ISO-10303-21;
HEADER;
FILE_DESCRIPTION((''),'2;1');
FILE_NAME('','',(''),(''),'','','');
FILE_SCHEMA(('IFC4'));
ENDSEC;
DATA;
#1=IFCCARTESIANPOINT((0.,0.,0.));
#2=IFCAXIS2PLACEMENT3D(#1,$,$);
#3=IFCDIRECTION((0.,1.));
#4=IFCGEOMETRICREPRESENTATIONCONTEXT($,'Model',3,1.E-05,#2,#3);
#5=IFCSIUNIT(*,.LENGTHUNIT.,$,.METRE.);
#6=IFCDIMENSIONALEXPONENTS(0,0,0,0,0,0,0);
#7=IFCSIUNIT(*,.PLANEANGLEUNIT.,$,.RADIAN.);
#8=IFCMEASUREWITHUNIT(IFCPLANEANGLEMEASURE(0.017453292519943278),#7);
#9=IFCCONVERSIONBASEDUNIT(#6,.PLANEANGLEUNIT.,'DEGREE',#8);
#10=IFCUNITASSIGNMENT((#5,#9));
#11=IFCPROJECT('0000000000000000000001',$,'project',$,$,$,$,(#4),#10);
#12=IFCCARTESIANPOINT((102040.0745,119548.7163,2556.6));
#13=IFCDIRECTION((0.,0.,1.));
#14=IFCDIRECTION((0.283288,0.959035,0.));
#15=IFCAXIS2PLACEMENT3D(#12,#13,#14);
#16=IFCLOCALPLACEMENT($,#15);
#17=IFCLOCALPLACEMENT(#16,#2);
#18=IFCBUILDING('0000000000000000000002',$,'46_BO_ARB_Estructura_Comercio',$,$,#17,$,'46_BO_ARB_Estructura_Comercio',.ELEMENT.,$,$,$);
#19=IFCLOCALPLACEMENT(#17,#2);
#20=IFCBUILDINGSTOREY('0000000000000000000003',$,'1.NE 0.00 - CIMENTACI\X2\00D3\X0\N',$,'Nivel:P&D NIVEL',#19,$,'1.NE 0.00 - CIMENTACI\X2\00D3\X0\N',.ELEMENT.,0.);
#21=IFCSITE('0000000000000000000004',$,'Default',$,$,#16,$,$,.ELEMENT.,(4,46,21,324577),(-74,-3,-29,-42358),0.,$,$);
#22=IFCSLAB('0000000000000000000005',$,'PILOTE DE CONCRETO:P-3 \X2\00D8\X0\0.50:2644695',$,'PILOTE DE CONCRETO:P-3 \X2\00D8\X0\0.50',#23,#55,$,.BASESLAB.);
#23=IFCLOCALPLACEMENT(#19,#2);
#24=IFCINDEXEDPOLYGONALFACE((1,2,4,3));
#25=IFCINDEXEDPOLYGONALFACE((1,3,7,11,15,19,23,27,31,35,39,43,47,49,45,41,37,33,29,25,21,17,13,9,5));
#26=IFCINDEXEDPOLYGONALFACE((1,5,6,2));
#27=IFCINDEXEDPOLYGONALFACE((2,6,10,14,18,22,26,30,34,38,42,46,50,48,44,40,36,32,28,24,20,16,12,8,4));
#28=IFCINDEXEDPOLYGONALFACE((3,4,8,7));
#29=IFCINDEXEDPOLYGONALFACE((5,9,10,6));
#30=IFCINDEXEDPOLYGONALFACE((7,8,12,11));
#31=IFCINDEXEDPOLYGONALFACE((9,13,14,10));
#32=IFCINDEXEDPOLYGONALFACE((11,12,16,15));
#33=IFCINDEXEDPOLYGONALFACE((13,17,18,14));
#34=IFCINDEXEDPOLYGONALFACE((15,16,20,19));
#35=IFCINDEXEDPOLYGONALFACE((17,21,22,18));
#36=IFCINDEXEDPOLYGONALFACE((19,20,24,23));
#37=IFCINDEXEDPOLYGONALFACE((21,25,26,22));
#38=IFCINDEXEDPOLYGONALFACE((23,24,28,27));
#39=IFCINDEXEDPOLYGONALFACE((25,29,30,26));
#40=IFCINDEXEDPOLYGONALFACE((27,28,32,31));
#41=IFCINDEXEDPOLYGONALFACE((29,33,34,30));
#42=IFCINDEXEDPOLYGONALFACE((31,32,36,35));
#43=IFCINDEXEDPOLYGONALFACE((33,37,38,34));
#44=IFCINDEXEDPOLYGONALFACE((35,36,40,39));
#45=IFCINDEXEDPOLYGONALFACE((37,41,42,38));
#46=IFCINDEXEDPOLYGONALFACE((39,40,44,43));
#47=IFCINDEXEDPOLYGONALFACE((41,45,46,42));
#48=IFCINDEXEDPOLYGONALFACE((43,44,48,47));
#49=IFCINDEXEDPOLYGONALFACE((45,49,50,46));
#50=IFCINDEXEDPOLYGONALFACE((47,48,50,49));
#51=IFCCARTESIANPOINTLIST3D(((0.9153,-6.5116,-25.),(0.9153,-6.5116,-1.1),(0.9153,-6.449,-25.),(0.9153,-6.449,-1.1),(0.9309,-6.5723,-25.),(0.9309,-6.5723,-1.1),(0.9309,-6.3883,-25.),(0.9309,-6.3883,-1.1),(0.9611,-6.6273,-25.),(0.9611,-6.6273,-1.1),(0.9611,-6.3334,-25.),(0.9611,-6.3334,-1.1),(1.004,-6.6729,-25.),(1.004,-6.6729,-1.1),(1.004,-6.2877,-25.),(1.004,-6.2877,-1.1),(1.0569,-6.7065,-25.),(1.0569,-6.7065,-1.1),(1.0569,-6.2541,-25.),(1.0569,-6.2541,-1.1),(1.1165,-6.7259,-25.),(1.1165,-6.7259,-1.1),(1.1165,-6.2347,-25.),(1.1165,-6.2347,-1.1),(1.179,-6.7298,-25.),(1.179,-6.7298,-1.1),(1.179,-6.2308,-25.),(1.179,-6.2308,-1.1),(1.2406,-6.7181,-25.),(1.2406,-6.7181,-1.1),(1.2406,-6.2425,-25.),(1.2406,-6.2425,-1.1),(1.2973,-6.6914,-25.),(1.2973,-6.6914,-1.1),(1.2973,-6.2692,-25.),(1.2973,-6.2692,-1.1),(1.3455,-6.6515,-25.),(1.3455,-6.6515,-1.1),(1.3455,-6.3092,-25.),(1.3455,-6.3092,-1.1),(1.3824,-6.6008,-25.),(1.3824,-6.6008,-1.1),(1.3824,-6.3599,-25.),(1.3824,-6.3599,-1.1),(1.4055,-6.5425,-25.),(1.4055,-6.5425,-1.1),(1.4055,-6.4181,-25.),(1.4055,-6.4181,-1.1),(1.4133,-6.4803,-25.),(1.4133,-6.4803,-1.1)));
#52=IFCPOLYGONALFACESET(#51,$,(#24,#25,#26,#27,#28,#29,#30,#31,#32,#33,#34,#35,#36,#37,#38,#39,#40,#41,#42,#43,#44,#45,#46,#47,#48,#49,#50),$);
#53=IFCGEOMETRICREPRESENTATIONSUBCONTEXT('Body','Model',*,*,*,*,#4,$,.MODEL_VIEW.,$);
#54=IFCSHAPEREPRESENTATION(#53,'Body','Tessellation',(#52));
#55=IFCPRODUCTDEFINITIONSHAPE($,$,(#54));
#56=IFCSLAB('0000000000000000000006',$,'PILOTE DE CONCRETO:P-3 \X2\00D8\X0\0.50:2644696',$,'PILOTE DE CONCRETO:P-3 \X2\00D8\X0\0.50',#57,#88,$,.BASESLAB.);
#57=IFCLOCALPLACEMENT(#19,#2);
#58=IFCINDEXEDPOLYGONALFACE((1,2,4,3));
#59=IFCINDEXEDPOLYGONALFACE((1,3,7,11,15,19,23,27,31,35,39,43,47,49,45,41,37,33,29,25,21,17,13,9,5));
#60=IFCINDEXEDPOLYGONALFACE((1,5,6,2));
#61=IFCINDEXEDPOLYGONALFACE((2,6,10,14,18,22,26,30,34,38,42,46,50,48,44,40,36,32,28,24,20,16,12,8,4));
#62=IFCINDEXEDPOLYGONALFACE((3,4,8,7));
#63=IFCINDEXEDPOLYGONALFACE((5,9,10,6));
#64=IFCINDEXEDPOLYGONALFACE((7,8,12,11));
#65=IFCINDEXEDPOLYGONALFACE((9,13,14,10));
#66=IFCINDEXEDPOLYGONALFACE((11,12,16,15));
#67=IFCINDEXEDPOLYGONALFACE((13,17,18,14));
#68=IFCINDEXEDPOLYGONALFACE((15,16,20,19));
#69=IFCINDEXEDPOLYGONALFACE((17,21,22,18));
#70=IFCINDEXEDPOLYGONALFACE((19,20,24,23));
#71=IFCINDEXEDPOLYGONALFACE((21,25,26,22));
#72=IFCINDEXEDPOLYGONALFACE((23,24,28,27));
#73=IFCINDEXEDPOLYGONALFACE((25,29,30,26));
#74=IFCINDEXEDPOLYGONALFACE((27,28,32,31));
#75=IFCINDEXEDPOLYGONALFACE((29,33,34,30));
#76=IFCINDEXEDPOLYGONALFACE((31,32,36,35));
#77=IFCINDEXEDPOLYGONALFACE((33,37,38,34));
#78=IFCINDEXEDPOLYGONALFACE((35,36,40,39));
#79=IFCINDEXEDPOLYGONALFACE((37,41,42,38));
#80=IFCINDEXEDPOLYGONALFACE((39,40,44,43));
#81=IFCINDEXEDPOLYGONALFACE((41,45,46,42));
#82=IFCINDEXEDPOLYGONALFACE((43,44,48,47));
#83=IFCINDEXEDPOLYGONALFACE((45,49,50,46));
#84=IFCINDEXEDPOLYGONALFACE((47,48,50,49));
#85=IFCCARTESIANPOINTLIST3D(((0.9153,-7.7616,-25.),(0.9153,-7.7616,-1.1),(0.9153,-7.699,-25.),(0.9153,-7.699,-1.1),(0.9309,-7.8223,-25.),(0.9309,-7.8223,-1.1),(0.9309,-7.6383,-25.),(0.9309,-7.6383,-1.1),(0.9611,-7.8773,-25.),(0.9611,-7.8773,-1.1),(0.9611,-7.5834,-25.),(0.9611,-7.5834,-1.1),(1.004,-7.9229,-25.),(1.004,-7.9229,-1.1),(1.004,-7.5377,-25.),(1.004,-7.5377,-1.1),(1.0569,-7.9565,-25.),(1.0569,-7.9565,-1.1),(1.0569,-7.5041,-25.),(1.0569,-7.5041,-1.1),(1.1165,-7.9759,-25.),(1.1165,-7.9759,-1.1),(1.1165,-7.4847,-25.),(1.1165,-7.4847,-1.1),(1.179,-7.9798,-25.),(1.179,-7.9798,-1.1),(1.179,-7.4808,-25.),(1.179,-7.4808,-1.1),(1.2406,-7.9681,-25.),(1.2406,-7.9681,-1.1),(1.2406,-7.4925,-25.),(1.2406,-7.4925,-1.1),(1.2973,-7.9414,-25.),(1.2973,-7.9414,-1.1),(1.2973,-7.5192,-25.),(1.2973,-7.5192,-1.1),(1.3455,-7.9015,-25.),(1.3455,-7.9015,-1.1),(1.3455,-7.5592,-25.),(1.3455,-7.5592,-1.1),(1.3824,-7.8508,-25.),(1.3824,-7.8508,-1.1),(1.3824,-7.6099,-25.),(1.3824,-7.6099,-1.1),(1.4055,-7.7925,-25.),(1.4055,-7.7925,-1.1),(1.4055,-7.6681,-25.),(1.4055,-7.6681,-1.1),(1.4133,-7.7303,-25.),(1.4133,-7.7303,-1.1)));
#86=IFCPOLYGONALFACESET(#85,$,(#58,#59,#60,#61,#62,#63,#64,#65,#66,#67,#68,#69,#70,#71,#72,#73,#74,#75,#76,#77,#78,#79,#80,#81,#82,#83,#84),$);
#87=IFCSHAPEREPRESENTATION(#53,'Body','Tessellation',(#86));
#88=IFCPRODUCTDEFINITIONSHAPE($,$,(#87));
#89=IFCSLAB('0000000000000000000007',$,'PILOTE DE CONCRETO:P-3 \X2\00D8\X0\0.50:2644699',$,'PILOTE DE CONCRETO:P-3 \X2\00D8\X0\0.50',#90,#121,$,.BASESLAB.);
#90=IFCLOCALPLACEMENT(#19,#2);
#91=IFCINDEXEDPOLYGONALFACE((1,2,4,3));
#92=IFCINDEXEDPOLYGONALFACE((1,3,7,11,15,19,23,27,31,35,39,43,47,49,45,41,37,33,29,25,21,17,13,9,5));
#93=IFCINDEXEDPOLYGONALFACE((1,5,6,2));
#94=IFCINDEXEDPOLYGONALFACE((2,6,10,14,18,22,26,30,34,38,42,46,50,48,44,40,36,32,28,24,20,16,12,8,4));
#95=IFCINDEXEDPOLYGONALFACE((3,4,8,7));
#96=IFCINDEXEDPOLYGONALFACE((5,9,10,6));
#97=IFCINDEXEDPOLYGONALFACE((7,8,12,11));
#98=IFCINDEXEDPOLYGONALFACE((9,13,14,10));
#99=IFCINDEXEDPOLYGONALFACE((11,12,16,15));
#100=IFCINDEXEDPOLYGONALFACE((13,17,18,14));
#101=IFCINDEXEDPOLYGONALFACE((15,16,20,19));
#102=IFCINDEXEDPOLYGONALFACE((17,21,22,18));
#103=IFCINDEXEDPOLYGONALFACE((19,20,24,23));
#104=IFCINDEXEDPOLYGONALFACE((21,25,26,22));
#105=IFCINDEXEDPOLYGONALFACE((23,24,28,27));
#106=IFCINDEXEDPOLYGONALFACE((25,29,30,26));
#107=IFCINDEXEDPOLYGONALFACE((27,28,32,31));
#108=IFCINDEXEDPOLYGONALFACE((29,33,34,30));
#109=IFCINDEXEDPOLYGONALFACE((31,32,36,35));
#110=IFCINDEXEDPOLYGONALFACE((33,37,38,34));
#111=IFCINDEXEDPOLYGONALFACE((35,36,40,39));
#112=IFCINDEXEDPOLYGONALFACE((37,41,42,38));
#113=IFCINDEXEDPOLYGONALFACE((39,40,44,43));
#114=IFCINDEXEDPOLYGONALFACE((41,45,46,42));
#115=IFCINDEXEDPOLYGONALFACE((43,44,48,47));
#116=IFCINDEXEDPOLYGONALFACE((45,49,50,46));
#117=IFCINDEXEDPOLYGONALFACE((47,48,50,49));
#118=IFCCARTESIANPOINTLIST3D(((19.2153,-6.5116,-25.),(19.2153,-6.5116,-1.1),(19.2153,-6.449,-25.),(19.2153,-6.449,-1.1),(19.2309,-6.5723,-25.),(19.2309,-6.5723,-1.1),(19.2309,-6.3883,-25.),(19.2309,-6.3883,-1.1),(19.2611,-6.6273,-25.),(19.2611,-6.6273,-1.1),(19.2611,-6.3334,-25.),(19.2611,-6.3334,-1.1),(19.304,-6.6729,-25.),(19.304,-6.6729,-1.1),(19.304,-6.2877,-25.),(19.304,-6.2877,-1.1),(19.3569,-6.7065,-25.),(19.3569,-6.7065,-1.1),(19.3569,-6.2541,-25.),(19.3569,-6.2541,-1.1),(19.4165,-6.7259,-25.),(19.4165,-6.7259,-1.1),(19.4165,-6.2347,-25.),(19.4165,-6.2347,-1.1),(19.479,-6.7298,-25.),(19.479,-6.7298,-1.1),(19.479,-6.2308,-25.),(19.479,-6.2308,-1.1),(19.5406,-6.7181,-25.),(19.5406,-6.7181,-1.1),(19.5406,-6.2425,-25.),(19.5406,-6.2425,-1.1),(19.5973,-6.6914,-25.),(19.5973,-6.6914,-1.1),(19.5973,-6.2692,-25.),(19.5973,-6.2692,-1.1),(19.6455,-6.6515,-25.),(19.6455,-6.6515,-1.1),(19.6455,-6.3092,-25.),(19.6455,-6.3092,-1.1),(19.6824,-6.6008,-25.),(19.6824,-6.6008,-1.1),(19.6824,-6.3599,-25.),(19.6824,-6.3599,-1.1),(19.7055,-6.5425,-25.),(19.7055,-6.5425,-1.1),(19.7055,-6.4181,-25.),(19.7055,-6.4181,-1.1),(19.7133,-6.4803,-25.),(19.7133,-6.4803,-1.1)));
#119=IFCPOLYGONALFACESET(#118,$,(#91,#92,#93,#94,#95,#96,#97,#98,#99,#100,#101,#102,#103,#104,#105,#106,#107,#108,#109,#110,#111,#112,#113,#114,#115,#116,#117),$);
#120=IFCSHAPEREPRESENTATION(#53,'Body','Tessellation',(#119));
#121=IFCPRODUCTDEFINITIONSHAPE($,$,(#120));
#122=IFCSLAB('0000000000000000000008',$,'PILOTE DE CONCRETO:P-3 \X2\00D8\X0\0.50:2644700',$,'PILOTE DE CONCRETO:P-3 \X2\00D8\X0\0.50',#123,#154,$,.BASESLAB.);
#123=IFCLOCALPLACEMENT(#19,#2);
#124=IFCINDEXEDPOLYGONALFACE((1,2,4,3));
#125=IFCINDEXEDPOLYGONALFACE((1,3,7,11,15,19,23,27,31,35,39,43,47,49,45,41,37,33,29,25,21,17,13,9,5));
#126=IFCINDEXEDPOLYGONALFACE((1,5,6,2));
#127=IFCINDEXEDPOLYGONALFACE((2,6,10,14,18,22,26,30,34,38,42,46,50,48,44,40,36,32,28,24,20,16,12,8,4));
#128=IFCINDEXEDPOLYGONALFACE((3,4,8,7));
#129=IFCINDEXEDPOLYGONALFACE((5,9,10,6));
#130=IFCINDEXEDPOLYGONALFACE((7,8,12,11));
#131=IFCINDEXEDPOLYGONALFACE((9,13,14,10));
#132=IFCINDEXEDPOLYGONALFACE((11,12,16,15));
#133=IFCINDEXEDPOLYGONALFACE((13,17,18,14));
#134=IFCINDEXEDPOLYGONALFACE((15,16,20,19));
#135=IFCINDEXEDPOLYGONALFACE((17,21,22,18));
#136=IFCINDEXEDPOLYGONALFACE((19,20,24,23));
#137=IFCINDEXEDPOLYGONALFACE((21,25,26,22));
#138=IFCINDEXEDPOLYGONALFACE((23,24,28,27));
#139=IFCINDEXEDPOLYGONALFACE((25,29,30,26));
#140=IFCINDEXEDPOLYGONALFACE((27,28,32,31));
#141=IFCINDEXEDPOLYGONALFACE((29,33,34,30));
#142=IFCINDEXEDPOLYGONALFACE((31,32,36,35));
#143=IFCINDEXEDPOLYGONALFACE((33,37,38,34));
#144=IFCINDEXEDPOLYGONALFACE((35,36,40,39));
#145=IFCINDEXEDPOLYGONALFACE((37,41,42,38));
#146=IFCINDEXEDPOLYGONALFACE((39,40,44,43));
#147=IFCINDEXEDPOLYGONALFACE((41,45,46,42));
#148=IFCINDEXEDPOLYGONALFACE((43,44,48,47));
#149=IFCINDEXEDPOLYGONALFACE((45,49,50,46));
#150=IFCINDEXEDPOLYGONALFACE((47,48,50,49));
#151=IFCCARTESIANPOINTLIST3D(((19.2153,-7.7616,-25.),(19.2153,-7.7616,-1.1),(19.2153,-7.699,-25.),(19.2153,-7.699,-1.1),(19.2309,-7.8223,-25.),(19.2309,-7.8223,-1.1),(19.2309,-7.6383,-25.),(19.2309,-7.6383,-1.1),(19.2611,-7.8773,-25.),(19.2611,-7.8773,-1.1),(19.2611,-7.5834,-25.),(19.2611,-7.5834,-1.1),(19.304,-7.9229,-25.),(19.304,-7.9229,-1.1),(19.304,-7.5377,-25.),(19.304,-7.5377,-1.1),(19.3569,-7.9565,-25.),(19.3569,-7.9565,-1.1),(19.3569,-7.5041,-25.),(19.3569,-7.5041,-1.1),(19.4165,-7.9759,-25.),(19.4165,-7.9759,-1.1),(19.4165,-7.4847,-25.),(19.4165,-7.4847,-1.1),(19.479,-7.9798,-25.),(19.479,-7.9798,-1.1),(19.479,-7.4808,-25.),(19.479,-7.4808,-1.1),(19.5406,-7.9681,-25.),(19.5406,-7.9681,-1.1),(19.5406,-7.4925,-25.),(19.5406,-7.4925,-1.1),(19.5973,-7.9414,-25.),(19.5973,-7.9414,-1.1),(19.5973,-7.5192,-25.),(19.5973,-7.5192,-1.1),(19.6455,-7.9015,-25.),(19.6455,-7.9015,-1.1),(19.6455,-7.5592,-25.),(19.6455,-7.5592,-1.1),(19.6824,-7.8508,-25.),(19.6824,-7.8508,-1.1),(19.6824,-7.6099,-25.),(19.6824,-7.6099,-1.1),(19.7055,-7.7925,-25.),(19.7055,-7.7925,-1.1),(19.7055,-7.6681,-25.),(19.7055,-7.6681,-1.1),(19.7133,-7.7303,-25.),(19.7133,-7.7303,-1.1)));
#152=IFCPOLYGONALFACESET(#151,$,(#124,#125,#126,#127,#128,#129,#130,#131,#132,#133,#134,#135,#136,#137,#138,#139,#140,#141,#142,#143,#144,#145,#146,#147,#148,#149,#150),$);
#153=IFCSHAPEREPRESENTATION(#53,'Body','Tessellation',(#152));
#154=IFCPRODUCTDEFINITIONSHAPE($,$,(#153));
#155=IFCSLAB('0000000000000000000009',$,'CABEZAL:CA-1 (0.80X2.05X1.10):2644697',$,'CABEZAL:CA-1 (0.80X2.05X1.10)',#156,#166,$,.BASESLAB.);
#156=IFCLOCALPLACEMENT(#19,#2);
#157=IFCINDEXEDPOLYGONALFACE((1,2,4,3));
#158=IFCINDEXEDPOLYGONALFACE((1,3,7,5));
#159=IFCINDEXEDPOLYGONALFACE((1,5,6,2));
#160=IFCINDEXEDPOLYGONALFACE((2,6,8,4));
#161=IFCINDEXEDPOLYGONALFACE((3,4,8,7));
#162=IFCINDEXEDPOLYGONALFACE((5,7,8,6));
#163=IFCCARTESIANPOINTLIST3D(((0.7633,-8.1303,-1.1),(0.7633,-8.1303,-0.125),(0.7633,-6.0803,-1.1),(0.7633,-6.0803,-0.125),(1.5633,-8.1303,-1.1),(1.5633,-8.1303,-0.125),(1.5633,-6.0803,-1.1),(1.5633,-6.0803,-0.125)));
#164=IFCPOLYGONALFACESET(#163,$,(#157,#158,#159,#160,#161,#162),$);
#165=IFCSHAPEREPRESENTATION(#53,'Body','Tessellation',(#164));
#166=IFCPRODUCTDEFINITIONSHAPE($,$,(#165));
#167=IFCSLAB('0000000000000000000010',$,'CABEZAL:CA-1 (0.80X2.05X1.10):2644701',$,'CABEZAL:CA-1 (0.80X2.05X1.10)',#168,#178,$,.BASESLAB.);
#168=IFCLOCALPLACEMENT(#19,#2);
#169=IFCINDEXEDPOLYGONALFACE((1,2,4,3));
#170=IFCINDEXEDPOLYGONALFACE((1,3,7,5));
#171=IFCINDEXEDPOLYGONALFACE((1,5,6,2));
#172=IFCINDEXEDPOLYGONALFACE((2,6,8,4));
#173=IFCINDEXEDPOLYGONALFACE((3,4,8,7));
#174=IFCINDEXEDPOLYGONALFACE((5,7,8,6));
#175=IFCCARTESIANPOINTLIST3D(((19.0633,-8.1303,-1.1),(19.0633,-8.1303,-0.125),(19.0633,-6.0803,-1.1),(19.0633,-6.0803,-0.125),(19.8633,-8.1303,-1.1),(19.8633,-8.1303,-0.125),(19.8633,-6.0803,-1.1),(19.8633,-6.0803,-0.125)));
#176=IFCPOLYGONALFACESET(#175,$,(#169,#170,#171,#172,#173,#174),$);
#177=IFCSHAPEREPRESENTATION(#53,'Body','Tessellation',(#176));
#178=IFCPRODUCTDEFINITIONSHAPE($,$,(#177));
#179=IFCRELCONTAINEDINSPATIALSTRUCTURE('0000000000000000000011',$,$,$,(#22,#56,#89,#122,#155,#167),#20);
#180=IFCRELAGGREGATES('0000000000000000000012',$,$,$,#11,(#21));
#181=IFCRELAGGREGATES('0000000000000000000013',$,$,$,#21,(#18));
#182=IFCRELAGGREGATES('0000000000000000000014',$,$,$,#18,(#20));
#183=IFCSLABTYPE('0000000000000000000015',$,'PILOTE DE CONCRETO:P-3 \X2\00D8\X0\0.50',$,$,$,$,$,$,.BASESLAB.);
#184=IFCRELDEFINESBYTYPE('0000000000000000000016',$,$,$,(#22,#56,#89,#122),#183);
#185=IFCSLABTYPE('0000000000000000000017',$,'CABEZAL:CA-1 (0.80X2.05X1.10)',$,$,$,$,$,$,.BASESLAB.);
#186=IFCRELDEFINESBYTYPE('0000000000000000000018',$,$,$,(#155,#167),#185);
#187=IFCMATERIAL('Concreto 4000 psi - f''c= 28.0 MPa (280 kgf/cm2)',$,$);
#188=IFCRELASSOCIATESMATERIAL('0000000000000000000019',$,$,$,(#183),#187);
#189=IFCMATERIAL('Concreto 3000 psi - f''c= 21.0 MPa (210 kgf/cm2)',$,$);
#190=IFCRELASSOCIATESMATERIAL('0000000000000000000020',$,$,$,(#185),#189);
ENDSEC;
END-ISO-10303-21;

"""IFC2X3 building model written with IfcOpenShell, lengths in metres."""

from ifc_helpers import new_model, entity, si_unit, converted_unit, direction, frame, origin, origin_2d_with_axis, place, context, subcontext, project, spatial, rectangle, circle, extrude, material, type_object, element, save


model = new_model("IFC2X3")

# Units and contexts
model_context = context("Model", 3, precision=1e-05, world=origin(), true_north=direction((0.0, 1.0)))
body_context = subcontext(model_context, "Body", "Model", "MODEL_VIEW")
ifc_project = project(units=[si_unit("LENGTHUNIT", "METRE"), converted_unit("PLANEANGLEUNIT", "DEGREE", entity("IfcPlaneAngleMeasure", 0.017453292519943278), si_unit("PLANEANGLEUNIT", "RADIAN"), dimensions=[0, 0, 0, 0, 0, 0, 0])], contexts=[model_context])

# Site, building, storey
site_placement = place(None, frame((102040.0745, 119548.7163, 2556.6), z_axis=(0.0, 0.0, 1.0), x_axis=(0.283288, 0.959035, 0.0)))
site = spatial("IfcSite", under=ifc_project, at=site_placement, Name="Default", CompositionType="ELEMENT", RefLatitude=(4, 46, 21, 324577), RefLongitude=(-74, -3, -29, -42358), RefElevation=0.0)
building_placement = place(site_placement, origin())
building = spatial("IfcBuilding", under=site, at=building_placement, Name="46_BO_ARB_Estructura_Comercio", LongName="46_BO_ARB_Estructura_Comercio", CompositionType="ELEMENT")
storey_placement = place(building_placement, origin())
storey = spatial("IfcBuildingStorey", under=building, at=storey_placement, Name="1.NE 0.00 - CIMENTACIÓN", ObjectType="Nivel:P&D NIVEL", LongName="1.NE 0.00 - CIMENTACIÓN", CompositionType="ELEMENT", Elevation=0.0)

# Shared definitions
ifc_material_1 = material(Name="Concreto 3000 psi - f'c= 21.0 MPa (210 kgf/cm2)")

# Slabs
ifc_material_2 = material(Name="Concreto 4000 psi - f'c= 28.0 MPa (280 kgf/cm2)")
slab_type_1 = type_object("IfcSlabType", Name="PILOTE DE CONCRETO:P-3 Ø0.50", PredefinedType="BASESLAB", material=ifc_material_2)
slab_1_placement = place(storey_placement, origin())
element("IfcSlab", 1, at=slab_1_placement, inside=storey, type_object=slab_type_1, Name="PILOTE DE CONCRETO:P-3 Ø0.50:2644695", ObjectType="PILOTE DE CONCRETO:P-3 Ø0.50", PredefinedType="BASESLAB", context=body_context, shape_type="SweptSolid", body=[
    extrude(circle(Radius=0.25, at=origin_2d_with_axis()), frame((1.1633, -6.4803, -25.0)), (0.0, 0.0, 1.0), 23.9),
])
slab_2_placement = place(storey_placement, origin())
element("IfcSlab", 2, at=slab_2_placement, inside=storey, type_object=slab_type_1, Name="PILOTE DE CONCRETO:P-3 Ø0.50:2644696", ObjectType="PILOTE DE CONCRETO:P-3 Ø0.50", PredefinedType="BASESLAB", context=body_context, shape_type="SweptSolid", body=[
    extrude(circle(Radius=0.25, at=origin_2d_with_axis()), frame((1.1633, -7.7303, -25.0)), (0.0, 0.0, 1.0), 23.9),
])
slab_3_placement = place(storey_placement, origin())
element("IfcSlab", 3, at=slab_3_placement, inside=storey, type_object=slab_type_1, Name="PILOTE DE CONCRETO:P-3 Ø0.50:2644699", ObjectType="PILOTE DE CONCRETO:P-3 Ø0.50", PredefinedType="BASESLAB", context=body_context, shape_type="SweptSolid", body=[
    extrude(circle(Radius=0.25, at=origin_2d_with_axis()), frame((19.4633, -6.4803, -25.0)), (0.0, 0.0, 1.0), 23.9),
])
slab_4_placement = place(storey_placement, origin())
element("IfcSlab", 4, at=slab_4_placement, inside=storey, type_object=slab_type_1, Name="PILOTE DE CONCRETO:P-3 Ø0.50:2644700", ObjectType="PILOTE DE CONCRETO:P-3 Ø0.50", PredefinedType="BASESLAB", context=body_context, shape_type="SweptSolid", body=[
    extrude(circle(Radius=0.25, at=origin_2d_with_axis()), frame((19.4633, -7.7303, -25.0)), (0.0, 0.0, 1.0), 23.9),
])
slab_type_2 = type_object("IfcSlabType", Name="CABEZAL:CA-1 (0.80X2.05X1.10)", PredefinedType="BASESLAB", material=ifc_material_1)
slab_5_placement = place(storey_placement, origin())
element("IfcSlab", 5, at=slab_5_placement, inside=storey, type_object=slab_type_2, Name="CABEZAL:CA-1 (0.80X2.05X1.10):2644697", ObjectType="CABEZAL:CA-1 (0.80X2.05X1.10)", PredefinedType="BASESLAB", context=body_context, shape_type="SweptSolid", body=[
    extrude(rectangle(XDim=0.8, YDim=2.05, at=origin_2d_with_axis()), frame((1.1633, -7.1053, -1.1), z_axis=(0.0, 0.0, 1.0), x_axis=(-1.0, 0.0, 0.0)), (0.0, 0.0, 1.0), 0.975),
])
slab_6_placement = place(storey_placement, origin())
element("IfcSlab", 6, at=slab_6_placement, inside=storey, type_object=slab_type_2, Name="CABEZAL:CA-1 (0.80X2.05X1.10):2644701", ObjectType="CABEZAL:CA-1 (0.80X2.05X1.10)", PredefinedType="BASESLAB", context=body_context, shape_type="SweptSolid", body=[
    extrude(rectangle(XDim=0.8, YDim=2.05, at=origin_2d_with_axis()), frame((19.4633, -7.1053, -1.1), z_axis=(0.0, 0.0, 1.0), x_axis=(-1.0, 0.0, 0.0)), (0.0, 0.0, 1.0), 0.975),
])

save(model, "model.ifc")
